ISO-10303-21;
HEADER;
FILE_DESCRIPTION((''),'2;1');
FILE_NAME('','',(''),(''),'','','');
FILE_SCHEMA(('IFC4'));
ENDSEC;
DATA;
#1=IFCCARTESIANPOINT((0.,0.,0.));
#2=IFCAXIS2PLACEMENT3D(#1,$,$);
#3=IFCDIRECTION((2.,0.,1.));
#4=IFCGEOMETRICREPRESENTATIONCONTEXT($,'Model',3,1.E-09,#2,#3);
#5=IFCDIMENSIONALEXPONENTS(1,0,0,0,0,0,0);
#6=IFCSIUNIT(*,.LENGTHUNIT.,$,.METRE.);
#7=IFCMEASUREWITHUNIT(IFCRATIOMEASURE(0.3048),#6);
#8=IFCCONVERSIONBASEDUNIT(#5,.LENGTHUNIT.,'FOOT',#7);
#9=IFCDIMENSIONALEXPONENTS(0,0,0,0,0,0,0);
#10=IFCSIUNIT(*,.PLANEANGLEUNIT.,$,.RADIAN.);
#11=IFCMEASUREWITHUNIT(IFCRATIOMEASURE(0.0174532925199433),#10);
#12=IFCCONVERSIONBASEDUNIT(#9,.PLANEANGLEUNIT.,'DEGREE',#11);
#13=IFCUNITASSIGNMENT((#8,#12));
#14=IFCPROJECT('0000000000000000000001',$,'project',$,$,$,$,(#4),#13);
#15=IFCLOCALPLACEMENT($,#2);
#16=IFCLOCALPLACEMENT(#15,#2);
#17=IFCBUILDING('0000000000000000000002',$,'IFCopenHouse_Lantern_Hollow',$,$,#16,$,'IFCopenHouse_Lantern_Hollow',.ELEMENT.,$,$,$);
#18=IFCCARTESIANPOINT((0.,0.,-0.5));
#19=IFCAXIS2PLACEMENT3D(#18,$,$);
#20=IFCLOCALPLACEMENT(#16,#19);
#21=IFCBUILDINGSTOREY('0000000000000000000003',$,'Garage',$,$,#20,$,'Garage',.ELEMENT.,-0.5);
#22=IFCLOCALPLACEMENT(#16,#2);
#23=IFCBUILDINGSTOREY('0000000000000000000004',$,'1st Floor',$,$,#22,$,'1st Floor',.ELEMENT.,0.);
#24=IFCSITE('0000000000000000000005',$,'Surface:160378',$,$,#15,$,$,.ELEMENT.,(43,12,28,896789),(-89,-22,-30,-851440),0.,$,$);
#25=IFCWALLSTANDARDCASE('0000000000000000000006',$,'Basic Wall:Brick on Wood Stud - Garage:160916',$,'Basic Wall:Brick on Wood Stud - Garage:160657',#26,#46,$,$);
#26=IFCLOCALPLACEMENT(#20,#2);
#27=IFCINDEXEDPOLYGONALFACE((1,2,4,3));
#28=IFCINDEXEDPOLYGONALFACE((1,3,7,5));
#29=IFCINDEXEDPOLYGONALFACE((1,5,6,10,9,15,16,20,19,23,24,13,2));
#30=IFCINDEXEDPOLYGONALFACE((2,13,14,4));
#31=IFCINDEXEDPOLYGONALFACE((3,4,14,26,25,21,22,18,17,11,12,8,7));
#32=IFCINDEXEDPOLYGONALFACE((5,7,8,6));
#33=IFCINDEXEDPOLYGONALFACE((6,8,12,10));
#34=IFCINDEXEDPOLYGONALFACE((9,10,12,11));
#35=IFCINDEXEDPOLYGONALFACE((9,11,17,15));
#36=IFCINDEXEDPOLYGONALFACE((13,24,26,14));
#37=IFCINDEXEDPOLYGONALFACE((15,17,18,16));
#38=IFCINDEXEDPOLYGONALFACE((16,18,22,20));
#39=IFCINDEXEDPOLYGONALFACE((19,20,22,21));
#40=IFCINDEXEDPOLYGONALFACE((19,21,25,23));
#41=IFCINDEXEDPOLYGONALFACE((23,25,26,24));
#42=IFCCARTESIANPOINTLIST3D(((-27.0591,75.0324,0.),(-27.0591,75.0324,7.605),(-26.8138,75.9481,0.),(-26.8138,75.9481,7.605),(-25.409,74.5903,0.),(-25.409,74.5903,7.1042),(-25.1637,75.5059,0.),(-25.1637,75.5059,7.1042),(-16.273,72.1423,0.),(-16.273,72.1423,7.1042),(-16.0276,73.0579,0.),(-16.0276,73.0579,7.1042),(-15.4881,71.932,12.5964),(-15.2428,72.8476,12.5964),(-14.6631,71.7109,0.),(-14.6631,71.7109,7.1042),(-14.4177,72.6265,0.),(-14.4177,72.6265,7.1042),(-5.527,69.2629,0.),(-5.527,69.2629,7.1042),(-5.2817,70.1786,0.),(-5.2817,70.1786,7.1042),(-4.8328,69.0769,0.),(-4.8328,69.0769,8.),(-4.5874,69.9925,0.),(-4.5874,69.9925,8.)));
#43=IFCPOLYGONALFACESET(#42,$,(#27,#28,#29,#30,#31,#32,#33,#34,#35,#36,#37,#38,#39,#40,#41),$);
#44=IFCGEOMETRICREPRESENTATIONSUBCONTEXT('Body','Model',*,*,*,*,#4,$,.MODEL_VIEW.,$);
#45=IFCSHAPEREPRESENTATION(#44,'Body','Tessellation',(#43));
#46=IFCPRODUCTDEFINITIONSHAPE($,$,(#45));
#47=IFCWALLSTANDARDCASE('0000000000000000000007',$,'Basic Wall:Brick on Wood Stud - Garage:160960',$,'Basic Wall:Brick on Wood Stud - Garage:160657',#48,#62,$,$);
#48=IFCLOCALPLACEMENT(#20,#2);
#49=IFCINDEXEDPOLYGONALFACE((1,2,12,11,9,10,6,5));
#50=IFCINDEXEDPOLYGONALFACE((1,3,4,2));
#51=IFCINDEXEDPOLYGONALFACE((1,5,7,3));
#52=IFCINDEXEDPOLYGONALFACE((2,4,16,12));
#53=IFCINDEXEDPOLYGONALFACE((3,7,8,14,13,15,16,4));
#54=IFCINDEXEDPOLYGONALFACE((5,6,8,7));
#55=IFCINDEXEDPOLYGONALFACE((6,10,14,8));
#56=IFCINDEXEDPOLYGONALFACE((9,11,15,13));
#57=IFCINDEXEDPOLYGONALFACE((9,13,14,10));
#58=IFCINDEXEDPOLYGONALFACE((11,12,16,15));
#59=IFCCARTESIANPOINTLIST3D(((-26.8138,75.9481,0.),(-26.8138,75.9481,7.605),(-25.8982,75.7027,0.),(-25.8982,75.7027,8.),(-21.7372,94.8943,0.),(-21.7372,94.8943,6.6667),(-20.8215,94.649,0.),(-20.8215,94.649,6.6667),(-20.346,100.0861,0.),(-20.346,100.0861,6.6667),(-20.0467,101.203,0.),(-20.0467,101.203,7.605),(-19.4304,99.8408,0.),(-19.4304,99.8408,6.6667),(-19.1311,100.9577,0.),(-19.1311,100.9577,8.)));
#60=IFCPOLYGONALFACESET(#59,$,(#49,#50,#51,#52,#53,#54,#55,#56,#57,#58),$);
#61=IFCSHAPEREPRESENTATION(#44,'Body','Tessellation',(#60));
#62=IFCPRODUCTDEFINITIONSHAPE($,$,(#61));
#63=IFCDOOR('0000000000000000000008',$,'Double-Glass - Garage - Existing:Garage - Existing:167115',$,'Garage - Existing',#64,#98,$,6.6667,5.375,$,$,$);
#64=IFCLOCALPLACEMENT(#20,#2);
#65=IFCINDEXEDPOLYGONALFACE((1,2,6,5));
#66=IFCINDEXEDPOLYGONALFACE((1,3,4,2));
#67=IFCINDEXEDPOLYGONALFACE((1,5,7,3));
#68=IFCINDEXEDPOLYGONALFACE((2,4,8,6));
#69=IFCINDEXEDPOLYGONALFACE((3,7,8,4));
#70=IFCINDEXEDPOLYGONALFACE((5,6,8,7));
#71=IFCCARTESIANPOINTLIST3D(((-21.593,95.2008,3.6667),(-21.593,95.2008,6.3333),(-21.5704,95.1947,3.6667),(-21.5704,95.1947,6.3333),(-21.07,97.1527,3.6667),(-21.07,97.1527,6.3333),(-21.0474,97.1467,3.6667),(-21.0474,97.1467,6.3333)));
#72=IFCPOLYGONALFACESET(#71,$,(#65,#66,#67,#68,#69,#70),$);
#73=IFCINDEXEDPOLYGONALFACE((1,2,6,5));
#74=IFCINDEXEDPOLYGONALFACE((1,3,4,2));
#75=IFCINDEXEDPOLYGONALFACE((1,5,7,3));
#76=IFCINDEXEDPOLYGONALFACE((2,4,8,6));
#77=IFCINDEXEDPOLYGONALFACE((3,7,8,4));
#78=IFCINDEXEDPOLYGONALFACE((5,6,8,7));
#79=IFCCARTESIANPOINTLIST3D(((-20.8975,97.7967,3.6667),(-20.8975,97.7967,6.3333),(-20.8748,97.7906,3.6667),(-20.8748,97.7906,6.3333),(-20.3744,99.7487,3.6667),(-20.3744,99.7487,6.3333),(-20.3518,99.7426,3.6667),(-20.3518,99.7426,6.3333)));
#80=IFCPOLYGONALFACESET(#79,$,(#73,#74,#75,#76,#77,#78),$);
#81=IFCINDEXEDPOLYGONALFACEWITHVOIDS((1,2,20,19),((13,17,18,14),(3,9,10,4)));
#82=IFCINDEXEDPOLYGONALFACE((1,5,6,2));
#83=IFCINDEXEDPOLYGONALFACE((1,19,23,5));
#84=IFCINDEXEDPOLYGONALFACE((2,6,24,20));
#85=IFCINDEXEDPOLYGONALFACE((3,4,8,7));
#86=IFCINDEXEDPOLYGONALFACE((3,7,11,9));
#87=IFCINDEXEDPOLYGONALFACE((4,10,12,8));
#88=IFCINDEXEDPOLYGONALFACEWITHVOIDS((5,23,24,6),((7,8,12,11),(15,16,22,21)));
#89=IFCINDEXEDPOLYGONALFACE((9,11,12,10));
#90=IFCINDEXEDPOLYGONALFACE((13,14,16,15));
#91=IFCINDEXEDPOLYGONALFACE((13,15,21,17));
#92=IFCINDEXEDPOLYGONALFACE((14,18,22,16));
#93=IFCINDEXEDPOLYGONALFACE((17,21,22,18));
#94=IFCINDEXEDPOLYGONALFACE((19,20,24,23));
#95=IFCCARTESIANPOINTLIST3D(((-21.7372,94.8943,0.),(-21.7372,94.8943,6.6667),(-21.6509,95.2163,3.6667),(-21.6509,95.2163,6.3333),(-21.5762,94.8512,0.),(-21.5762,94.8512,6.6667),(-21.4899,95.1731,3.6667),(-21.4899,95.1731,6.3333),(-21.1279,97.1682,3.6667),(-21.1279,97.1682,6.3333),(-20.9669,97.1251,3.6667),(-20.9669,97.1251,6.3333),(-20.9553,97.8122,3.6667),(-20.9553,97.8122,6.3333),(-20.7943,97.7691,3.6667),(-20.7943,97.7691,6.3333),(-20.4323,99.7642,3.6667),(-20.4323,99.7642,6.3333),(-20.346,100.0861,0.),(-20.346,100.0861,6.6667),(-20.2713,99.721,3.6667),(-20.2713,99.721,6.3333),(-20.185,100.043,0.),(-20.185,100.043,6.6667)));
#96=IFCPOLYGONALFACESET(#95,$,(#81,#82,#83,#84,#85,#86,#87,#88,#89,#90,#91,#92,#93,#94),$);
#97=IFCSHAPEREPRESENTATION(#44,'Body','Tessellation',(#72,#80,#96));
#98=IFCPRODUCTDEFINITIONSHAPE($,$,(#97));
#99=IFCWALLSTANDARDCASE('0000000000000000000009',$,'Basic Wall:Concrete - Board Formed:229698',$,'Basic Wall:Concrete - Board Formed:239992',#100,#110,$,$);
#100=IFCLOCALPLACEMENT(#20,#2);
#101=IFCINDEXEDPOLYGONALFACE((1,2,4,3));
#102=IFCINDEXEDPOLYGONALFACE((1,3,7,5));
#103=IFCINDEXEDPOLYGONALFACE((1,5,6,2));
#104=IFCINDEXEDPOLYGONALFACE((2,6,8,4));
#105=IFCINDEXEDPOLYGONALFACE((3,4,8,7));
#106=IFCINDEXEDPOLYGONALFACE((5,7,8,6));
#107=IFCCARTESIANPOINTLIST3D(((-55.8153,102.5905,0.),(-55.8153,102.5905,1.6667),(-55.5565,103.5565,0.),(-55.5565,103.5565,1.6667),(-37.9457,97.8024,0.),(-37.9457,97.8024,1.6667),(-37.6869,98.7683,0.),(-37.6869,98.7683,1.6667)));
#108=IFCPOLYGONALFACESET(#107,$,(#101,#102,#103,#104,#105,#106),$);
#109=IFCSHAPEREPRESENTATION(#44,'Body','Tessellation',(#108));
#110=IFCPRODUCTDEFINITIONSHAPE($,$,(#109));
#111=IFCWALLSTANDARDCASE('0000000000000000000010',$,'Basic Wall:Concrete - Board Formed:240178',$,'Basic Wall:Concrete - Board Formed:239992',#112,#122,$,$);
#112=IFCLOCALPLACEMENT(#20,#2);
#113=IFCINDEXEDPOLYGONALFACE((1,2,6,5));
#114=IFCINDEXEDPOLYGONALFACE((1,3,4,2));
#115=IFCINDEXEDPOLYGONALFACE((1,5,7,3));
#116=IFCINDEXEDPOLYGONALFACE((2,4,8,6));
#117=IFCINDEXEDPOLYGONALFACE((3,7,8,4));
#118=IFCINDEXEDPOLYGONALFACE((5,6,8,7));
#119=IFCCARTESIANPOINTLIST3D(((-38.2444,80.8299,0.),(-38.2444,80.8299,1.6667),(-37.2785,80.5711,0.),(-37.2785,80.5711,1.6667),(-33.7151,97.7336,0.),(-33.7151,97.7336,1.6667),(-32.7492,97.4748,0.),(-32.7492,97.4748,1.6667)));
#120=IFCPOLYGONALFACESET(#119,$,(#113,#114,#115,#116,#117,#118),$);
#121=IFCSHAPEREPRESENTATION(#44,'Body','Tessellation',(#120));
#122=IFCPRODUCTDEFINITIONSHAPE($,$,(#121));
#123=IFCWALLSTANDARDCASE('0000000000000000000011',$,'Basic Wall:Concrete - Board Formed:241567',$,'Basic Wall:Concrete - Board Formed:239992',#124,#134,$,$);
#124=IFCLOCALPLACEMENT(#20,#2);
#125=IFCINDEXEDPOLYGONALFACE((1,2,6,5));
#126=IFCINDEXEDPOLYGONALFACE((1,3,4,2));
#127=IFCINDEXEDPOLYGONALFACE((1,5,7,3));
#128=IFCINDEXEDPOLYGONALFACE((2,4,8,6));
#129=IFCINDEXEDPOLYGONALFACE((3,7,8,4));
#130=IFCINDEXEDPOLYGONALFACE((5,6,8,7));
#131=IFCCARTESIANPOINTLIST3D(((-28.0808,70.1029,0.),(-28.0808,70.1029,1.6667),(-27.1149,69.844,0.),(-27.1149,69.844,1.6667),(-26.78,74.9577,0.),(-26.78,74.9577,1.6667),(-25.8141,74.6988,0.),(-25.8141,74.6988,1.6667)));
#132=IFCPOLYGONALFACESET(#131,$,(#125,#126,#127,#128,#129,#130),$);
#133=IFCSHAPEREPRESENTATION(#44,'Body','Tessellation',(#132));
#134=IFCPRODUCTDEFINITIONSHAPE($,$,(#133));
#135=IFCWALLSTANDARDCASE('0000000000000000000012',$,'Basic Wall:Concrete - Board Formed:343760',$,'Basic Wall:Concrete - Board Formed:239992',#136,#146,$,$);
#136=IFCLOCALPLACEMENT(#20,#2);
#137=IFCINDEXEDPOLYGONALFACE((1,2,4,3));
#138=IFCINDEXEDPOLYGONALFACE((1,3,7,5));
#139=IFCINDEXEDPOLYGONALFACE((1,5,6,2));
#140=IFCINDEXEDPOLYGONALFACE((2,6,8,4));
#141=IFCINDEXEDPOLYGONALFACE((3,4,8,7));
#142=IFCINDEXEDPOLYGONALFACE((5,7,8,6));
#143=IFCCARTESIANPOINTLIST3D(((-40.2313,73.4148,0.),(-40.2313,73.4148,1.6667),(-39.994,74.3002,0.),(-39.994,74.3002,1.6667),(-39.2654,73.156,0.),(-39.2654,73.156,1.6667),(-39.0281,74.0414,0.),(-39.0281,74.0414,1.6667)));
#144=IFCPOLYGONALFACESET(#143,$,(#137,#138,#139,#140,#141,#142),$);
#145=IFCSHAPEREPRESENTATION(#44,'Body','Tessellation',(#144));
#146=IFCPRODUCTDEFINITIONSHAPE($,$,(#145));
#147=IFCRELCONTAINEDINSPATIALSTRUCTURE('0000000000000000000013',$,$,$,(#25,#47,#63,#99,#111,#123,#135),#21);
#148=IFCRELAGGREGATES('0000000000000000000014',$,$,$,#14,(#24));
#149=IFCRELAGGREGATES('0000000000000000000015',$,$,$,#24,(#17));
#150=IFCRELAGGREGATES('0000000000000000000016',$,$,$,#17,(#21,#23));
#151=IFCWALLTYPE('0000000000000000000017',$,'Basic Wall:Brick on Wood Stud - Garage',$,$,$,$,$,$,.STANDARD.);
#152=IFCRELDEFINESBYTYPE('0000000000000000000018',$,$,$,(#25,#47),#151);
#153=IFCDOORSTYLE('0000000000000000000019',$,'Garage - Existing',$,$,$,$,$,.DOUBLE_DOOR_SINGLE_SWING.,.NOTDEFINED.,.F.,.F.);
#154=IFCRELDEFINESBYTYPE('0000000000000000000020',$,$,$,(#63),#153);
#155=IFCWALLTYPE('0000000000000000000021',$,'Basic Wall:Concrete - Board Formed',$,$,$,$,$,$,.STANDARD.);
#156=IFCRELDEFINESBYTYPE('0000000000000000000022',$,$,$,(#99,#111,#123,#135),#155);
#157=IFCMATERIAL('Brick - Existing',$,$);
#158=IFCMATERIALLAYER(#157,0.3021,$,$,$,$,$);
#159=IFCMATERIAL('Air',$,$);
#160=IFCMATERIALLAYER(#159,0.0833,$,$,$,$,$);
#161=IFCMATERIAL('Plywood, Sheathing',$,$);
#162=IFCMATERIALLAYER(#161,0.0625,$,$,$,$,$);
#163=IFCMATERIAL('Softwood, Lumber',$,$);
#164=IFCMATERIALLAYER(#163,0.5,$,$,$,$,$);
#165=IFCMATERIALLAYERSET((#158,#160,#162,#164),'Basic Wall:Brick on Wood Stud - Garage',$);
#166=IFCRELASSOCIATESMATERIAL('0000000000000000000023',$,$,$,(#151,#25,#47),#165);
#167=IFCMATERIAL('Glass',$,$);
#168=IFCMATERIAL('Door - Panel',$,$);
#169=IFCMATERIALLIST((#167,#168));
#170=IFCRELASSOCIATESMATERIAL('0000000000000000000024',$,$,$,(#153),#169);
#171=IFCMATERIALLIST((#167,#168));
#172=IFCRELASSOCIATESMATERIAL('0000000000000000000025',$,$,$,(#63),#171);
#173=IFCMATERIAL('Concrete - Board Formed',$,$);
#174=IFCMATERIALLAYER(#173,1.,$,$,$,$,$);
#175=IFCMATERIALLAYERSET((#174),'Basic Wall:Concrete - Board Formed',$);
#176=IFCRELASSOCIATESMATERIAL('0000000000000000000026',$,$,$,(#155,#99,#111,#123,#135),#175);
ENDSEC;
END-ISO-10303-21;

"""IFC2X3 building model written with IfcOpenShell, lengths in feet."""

from ifc_helpers import new_model, entity, si_unit, converted_unit, direction, frame, frame_2d, origin, origin_2d_with_axis, place, context, subcontext, project, spatial, polyline, rectangle, outline, extrude, clip, bounded_halfspace, source, transform, mapped, material, material_list, layer, layer_set, layer_usage, type_object, type_shapes, element, fill, save


model = new_model("IFC2X3")

# Units and contexts
model_context = context("Model", 3, precision=1e-09, world=origin(), true_north=direction((2.0, 0.0, 1.0)))
body_context = subcontext(model_context, "Body", "Model", "MODEL_VIEW")
ifc_project = project(units=[converted_unit("LENGTHUNIT", "FOOT", entity("IfcRatioMeasure", 0.3048), si_unit("LENGTHUNIT", "METRE"), dimensions=[1, 0, 0, 0, 0, 0, 0]), converted_unit("PLANEANGLEUNIT", "DEGREE", entity("IfcRatioMeasure", 0.0174532925199433), si_unit("PLANEANGLEUNIT", "RADIAN"), dimensions=[0, 0, 0, 0, 0, 0, 0])], contexts=[model_context])

# Site, building, storey
site_placement = place(None, origin())
site = spatial("IfcSite", under=ifc_project, at=site_placement, Name="Surface:160378", CompositionType="ELEMENT", RefLatitude=(43, 12, 28, 896789), RefLongitude=(-89, -22, -30, -851440), RefElevation=0.0)
building_placement = place(site_placement, origin())
building = spatial("IfcBuilding", under=site, at=building_placement, Name="IFCopenHouse_Lantern_Hollow", LongName="IFCopenHouse_Lantern_Hollow", CompositionType="ELEMENT")
storey_1_placement = place(building_placement, frame((0.0, 0.0, -0.5)))
storey_1 = spatial("IfcBuildingStorey", under=building, at=storey_1_placement, Name="Garage", LongName="Garage", CompositionType="ELEMENT", Elevation=-0.5)

# Shared definitions
ifc_material_1 = material(Name="Softwood, Lumber")

# Shared definitions
ifc_material_2 = material(Name="Brick - Existing")
ifc_layer_1 = layer(ifc_material_2, 0.3021)
ifc_material_3 = material(Name="Air")
ifc_layer_2 = layer(ifc_material_3, 0.0833)
ifc_material_4 = material(Name="Plywood, Sheathing")
ifc_layer_3 = layer(ifc_material_4, 0.0625)
ifc_layer_4 = layer(ifc_material_1, 0.5)
ifc_layer_set_1 = layer_set([ifc_layer_1, ifc_layer_2, ifc_layer_3, ifc_layer_4], Name="Basic Wall:Brick on Wood Stud - Garage")
wall_type_1 = type_object("IfcWallType", Name="Basic Wall:Brick on Wood Stud - Garage", PredefinedType="STANDARD", material=ifc_layer_set_1)

# Shared definitions
storey_2_placement = place(building_placement, origin())
storey_2 = spatial("IfcBuildingStorey", under=building, at=storey_2_placement, Name="1st Floor", LongName="1st Floor", CompositionType="ELEMENT", Elevation=0.0)

# Shared definitions
ifc_material_5 = material(Name="Glass")

# Wall, openings
ifc_layer_usage_1 = layer_usage(ifc_layer_set_1, "AXIS2", "NEGATIVE", 0.474)
wall_1_placement = place(storey_1_placement, frame((-4.7101, 69.5347, 0.0), z_axis=(0.0, 0.0, 1.0), x_axis=(-0.965926, 0.258819, 0.0)))
wall_1 = element("IfcWallStandardCase", 1, at=wall_1_placement, inside=storey_1, type_object=wall_type_1, material=ifc_layer_usage_1, Name="Basic Wall:Brick on Wood Stud - Garage:160916", ObjectType="Basic Wall:Brick on Wood Stud - Garage:160657", context=body_context, shape_type="Clipping", body=[
    clip(clip(extrude(rectangle(XDim=23.0104, YDim=0.9479, at=frame_2d((11.5052, 0.0), x_axis=(-1.0, 0.0))), origin(), (0.0, 0.0, 1.0), 12.5964), bounded_halfspace(frame((0.0, 0.474, 8.0), z_axis=(-0.384615, 0.0, 0.923077), x_axis=(0.0, -1.0, 0.0)), False, frame((0.0, 0.474, 8.0)), polyline([(0.0, 0.0), (0.0, -0.9479), (11.0313, -0.9479), (11.0313, 0.0), (0.0, 0.0)]))), bounded_halfspace(frame((23.0104, -0.474, 7.605), z_axis=(0.384615, 0.0, 0.923077), x_axis=(0.0, 1.0, 0.0)), False, frame((23.0104, -0.474, 7.605)), polyline([(0.0, 0.0), (0.0, 0.9479), (-11.9792, 0.9479), (-11.9792, 0.0), (-0.9479, 0.0), (0.0, 0.0)]))),
])
opening_1_placement = place(wall_1_placement, frame((0.7188, -0.474, 0.0)))
element("IfcOpeningElement", 2, at=opening_1_placement, cuts=wall_1, ObjectType="Opening", context=body_context, shape_type="SweptSolid", body=[
    extrude(rectangle(XDim=7.1042, YDim=9.4583, at=frame_2d((3.5521, 4.7292), x_axis=(1.0, 0.0))), frame((0.0, 0.0, 0.0), z_axis=(0.0, 1.0, 0.0), x_axis=(0.0, 0.0, 1.0)), (0.0, 0.0, 1.0), 0.9479),
])
opening_2_placement = place(wall_1_placement, frame((11.8438, -0.474, 0.0)))
element("IfcOpeningElement", 3, at=opening_2_placement, cuts=wall_1, ObjectType="Opening", context=body_context, shape_type="SweptSolid", body=[
    extrude(rectangle(XDim=7.1042, YDim=9.4583, at=frame_2d((3.5521, 4.7292), x_axis=(1.0, 0.0))), frame((0.0, 0.0, 0.0), z_axis=(0.0, 1.0, 0.0), x_axis=(0.0, 0.0, 1.0)), (0.0, 0.0, 1.0), 0.9479),
])

# Wall, opening, door
ifc_layer_usage_2 = layer_usage(ifc_layer_set_1, "AXIS2", "NEGATIVE", 0.474)
wall_2_placement = place(storey_1_placement, frame((-26.356, 75.8254, 0.0), z_axis=(0.0, 0.0, 1.0), x_axis=(0.258819, 0.965926, 0.0)))
wall_2 = element("IfcWallStandardCase", 4, at=wall_2_placement, inside=storey_1, type_object=wall_type_1, material=ifc_layer_usage_2, Name="Basic Wall:Brick on Wood Stud - Garage:160960", ObjectType="Basic Wall:Brick on Wood Stud - Garage:160657", context=body_context, shape_type="Clipping", body=[
    clip(extrude(rectangle(XDim=26.1458, YDim=0.9479, at=frame_2d((13.0729, 0.0), x_axis=(-1.0, 0.0))), origin(), (0.0, 0.0, 1.0), 8.0), bounded_halfspace(frame((0.0, -0.474, 8.0), z_axis=(0.0, 0.384615, 0.923077), x_axis=(-1.0, 0.0, 0.0)), False, frame((0.0, -0.474, 8.0)), polyline([(0.0, 0.0), (26.1458, 0.0), (26.1458, 0.9479), (0.0, 0.9479), (0.0, 0.0)]))),
])
opening_3_placement = place(wall_2_placement, frame((19.6146, -0.474, 0.0)))
opening_3 = element("IfcOpeningElement", 5, at=opening_3_placement, cuts=wall_2, ObjectType="Opening", context=body_context, shape_type="SweptSolid", body=[
    extrude(rectangle(XDim=5.375, YDim=6.6667, at=frame_2d((3.3333, 2.6875), x_axis=(0.0, -1.0))), frame((0.0, 0.0, 0.0), z_axis=(0.0, 1.0, 0.0), x_axis=(0.0, 0.0, 1.0)), (0.0, 0.0, 1.0), 0.9479),
])
ifc_material_6 = material(Name="Door - Panel")
ifc_material_list_1 = material_list([ifc_material_5, ifc_material_6])
ifc_material_list_2 = material_list([ifc_material_5, ifc_material_6])
door_style = type_object("IfcDoorStyle", Name="Garage - Existing", ConstructionType="NOTDEFINED", OperationType="DOUBLE_DOOR_SINGLE_SWING", ParameterTakesPrecedence=False, Sizeable=False, material=ifc_material_list_2)
shared_shape_1 = source(origin(), body_context, "Body", "SweptSolid", [
    extrude(rectangle(XDim=2.0208, YDim=0.0234, at=frame_2d((0.0, 0.0), x_axis=(1.0, 0.0))), frame((1.3438, 0.8919, 3.6667)), (0.0, 0.0, 1.0), 2.6667),
    extrude(rectangle(XDim=2.0208, YDim=0.0234, at=origin_2d_with_axis()), frame((4.0312, 0.8919, 3.6667)), (0.0, 0.0, 1.0), 2.6667),
    extrude(outline(polyline([(-3.3333, -2.6875), (3.3333, -2.6875), (3.3333, 2.6875), (-3.3333, 2.6875), (-3.3333, -2.6875)]), holes=[polyline([(-3.0, 0.3333), (-3.0, 2.3542), (-0.3333, 2.3542), (-0.3333, 0.3333), (-3.0, 0.3333)]), polyline([(-3.0, -2.3542), (-3.0, -0.3333), (-0.3333, -0.3333), (-0.3333, -2.3542), (-3.0, -2.3542)])]), frame((2.6875, 0.9635, 3.3333), z_axis=(0.0, -1.0, 0.0), x_axis=(0.0, 0.0, -1.0)), (0.0, 0.0, 1.0), 0.1667),
])
type_shapes(door_style, [shared_shape_1])
door_placement = place(opening_3_placement, frame((0.0, -0.0156, 0.0)))
door = element("IfcDoor", 6, at=door_placement, inside=storey_1, type_object=door_style, material=ifc_material_list_1, Name="Double-Glass - Garage - Existing:Garage - Existing:167115", ObjectType="Garage - Existing", OverallHeight=6.6667, OverallWidth=5.375, context=body_context, shape_type="MappedRepresentation", body=[
    mapped(shared_shape_1, transform((0.0, 0.0, 0.0), scale=1.0)),
])
fill(opening_3, door)

# Walls
ifc_material_7 = material(Name="Concrete - Board Formed")
ifc_layer_5 = layer(ifc_material_7, 1.0)
ifc_layer_set_2 = layer_set([ifc_layer_5], Name="Basic Wall:Concrete - Board Formed")
ifc_layer_usage_3 = layer_usage(ifc_layer_set_2, "AXIS2", "NEGATIVE", 0.5)
wall_type_2 = type_object("IfcWallType", Name="Basic Wall:Concrete - Board Formed", PredefinedType="STANDARD", material=ifc_layer_set_2)
wall_3_placement = place(storey_1_placement, frame((-55.6859, 103.0735, 0.0), z_axis=(0.0, 0.0, 1.0), x_axis=(0.965926, -0.258819, 0.0)))
element("IfcWallStandardCase", 7, at=wall_3_placement, inside=storey_1, type_object=wall_type_2, material=ifc_layer_usage_3, Name="Basic Wall:Concrete - Board Formed:229698", ObjectType="Basic Wall:Concrete - Board Formed:239992", context=body_context, shape_type="SweptSolid", body=[
    extrude(rectangle(XDim=18.5, YDim=1.0, at=frame_2d((9.25, 0.0), x_axis=(-1.0, 0.0))), origin(), (0.0, 0.0, 1.0), 1.6667),
])
ifc_layer_usage_4 = layer_usage(ifc_layer_set_2, "AXIS2", "NEGATIVE", 0.5)
wall_4_placement = place(storey_1_placement, frame((-33.2321, 97.6042, 0.0), z_axis=(0.0, 0.0, 1.0), x_axis=(-0.258819, -0.965926, 0.0)))
element("IfcWallStandardCase", 8, at=wall_4_placement, inside=storey_1, type_object=wall_type_2, material=ifc_layer_usage_4, Name="Basic Wall:Concrete - Board Formed:240178", ObjectType="Basic Wall:Concrete - Board Formed:239992", context=body_context, shape_type="SweptSolid", body=[
    extrude(rectangle(XDim=17.5, YDim=1.0, at=frame_2d((8.75, 0.0), x_axis=(-1.0, 0.0))), origin(), (0.0, 0.0, 1.0), 1.6667),
])
ifc_layer_usage_5 = layer_usage(ifc_layer_set_2, "AXIS2", "NEGATIVE", 0.5)
wall_5_placement = place(storey_1_placement, frame((-26.297, 74.8282, 0.0), z_axis=(0.0, 0.0, 1.0), x_axis=(-0.258819, -0.965926, 0.0)))
element("IfcWallStandardCase", 9, at=wall_5_placement, inside=storey_1, type_object=wall_type_2, material=ifc_layer_usage_5, Name="Basic Wall:Concrete - Board Formed:241567", ObjectType="Basic Wall:Concrete - Board Formed:239992", context=body_context, shape_type="SweptSolid", body=[
    extrude(rectangle(XDim=5.026, YDim=1.0, at=frame_2d((2.513, 0.0), x_axis=(-1.0, 0.0))), origin(), (0.0, 0.0, 1.0), 1.6667),
])
ifc_layer_usage_6 = layer_usage(ifc_layer_set_2, "AXIS2", "NEGATIVE", 0.5)
wall_6_placement = place(storey_1_placement, frame((-39.5111, 74.1708, 0.0), z_axis=(0.0, 0.0, 1.0), x_axis=(-0.258819, -0.965926, 0.0)))
element("IfcWallStandardCase", 10, at=wall_6_placement, inside=storey_1, type_object=wall_type_2, material=ifc_layer_usage_6, Name="Basic Wall:Concrete - Board Formed:343760", ObjectType="Basic Wall:Concrete - Board Formed:239992", context=body_context, shape_type="SweptSolid", body=[
    extrude(rectangle(XDim=0.9167, YDim=1.0, at=frame_2d((0.4583, 0.0), x_axis=(-1.0, 0.0))), origin(), (0.0, 0.0, 1.0), 1.6667),
])

save(model, "model.ifc")
